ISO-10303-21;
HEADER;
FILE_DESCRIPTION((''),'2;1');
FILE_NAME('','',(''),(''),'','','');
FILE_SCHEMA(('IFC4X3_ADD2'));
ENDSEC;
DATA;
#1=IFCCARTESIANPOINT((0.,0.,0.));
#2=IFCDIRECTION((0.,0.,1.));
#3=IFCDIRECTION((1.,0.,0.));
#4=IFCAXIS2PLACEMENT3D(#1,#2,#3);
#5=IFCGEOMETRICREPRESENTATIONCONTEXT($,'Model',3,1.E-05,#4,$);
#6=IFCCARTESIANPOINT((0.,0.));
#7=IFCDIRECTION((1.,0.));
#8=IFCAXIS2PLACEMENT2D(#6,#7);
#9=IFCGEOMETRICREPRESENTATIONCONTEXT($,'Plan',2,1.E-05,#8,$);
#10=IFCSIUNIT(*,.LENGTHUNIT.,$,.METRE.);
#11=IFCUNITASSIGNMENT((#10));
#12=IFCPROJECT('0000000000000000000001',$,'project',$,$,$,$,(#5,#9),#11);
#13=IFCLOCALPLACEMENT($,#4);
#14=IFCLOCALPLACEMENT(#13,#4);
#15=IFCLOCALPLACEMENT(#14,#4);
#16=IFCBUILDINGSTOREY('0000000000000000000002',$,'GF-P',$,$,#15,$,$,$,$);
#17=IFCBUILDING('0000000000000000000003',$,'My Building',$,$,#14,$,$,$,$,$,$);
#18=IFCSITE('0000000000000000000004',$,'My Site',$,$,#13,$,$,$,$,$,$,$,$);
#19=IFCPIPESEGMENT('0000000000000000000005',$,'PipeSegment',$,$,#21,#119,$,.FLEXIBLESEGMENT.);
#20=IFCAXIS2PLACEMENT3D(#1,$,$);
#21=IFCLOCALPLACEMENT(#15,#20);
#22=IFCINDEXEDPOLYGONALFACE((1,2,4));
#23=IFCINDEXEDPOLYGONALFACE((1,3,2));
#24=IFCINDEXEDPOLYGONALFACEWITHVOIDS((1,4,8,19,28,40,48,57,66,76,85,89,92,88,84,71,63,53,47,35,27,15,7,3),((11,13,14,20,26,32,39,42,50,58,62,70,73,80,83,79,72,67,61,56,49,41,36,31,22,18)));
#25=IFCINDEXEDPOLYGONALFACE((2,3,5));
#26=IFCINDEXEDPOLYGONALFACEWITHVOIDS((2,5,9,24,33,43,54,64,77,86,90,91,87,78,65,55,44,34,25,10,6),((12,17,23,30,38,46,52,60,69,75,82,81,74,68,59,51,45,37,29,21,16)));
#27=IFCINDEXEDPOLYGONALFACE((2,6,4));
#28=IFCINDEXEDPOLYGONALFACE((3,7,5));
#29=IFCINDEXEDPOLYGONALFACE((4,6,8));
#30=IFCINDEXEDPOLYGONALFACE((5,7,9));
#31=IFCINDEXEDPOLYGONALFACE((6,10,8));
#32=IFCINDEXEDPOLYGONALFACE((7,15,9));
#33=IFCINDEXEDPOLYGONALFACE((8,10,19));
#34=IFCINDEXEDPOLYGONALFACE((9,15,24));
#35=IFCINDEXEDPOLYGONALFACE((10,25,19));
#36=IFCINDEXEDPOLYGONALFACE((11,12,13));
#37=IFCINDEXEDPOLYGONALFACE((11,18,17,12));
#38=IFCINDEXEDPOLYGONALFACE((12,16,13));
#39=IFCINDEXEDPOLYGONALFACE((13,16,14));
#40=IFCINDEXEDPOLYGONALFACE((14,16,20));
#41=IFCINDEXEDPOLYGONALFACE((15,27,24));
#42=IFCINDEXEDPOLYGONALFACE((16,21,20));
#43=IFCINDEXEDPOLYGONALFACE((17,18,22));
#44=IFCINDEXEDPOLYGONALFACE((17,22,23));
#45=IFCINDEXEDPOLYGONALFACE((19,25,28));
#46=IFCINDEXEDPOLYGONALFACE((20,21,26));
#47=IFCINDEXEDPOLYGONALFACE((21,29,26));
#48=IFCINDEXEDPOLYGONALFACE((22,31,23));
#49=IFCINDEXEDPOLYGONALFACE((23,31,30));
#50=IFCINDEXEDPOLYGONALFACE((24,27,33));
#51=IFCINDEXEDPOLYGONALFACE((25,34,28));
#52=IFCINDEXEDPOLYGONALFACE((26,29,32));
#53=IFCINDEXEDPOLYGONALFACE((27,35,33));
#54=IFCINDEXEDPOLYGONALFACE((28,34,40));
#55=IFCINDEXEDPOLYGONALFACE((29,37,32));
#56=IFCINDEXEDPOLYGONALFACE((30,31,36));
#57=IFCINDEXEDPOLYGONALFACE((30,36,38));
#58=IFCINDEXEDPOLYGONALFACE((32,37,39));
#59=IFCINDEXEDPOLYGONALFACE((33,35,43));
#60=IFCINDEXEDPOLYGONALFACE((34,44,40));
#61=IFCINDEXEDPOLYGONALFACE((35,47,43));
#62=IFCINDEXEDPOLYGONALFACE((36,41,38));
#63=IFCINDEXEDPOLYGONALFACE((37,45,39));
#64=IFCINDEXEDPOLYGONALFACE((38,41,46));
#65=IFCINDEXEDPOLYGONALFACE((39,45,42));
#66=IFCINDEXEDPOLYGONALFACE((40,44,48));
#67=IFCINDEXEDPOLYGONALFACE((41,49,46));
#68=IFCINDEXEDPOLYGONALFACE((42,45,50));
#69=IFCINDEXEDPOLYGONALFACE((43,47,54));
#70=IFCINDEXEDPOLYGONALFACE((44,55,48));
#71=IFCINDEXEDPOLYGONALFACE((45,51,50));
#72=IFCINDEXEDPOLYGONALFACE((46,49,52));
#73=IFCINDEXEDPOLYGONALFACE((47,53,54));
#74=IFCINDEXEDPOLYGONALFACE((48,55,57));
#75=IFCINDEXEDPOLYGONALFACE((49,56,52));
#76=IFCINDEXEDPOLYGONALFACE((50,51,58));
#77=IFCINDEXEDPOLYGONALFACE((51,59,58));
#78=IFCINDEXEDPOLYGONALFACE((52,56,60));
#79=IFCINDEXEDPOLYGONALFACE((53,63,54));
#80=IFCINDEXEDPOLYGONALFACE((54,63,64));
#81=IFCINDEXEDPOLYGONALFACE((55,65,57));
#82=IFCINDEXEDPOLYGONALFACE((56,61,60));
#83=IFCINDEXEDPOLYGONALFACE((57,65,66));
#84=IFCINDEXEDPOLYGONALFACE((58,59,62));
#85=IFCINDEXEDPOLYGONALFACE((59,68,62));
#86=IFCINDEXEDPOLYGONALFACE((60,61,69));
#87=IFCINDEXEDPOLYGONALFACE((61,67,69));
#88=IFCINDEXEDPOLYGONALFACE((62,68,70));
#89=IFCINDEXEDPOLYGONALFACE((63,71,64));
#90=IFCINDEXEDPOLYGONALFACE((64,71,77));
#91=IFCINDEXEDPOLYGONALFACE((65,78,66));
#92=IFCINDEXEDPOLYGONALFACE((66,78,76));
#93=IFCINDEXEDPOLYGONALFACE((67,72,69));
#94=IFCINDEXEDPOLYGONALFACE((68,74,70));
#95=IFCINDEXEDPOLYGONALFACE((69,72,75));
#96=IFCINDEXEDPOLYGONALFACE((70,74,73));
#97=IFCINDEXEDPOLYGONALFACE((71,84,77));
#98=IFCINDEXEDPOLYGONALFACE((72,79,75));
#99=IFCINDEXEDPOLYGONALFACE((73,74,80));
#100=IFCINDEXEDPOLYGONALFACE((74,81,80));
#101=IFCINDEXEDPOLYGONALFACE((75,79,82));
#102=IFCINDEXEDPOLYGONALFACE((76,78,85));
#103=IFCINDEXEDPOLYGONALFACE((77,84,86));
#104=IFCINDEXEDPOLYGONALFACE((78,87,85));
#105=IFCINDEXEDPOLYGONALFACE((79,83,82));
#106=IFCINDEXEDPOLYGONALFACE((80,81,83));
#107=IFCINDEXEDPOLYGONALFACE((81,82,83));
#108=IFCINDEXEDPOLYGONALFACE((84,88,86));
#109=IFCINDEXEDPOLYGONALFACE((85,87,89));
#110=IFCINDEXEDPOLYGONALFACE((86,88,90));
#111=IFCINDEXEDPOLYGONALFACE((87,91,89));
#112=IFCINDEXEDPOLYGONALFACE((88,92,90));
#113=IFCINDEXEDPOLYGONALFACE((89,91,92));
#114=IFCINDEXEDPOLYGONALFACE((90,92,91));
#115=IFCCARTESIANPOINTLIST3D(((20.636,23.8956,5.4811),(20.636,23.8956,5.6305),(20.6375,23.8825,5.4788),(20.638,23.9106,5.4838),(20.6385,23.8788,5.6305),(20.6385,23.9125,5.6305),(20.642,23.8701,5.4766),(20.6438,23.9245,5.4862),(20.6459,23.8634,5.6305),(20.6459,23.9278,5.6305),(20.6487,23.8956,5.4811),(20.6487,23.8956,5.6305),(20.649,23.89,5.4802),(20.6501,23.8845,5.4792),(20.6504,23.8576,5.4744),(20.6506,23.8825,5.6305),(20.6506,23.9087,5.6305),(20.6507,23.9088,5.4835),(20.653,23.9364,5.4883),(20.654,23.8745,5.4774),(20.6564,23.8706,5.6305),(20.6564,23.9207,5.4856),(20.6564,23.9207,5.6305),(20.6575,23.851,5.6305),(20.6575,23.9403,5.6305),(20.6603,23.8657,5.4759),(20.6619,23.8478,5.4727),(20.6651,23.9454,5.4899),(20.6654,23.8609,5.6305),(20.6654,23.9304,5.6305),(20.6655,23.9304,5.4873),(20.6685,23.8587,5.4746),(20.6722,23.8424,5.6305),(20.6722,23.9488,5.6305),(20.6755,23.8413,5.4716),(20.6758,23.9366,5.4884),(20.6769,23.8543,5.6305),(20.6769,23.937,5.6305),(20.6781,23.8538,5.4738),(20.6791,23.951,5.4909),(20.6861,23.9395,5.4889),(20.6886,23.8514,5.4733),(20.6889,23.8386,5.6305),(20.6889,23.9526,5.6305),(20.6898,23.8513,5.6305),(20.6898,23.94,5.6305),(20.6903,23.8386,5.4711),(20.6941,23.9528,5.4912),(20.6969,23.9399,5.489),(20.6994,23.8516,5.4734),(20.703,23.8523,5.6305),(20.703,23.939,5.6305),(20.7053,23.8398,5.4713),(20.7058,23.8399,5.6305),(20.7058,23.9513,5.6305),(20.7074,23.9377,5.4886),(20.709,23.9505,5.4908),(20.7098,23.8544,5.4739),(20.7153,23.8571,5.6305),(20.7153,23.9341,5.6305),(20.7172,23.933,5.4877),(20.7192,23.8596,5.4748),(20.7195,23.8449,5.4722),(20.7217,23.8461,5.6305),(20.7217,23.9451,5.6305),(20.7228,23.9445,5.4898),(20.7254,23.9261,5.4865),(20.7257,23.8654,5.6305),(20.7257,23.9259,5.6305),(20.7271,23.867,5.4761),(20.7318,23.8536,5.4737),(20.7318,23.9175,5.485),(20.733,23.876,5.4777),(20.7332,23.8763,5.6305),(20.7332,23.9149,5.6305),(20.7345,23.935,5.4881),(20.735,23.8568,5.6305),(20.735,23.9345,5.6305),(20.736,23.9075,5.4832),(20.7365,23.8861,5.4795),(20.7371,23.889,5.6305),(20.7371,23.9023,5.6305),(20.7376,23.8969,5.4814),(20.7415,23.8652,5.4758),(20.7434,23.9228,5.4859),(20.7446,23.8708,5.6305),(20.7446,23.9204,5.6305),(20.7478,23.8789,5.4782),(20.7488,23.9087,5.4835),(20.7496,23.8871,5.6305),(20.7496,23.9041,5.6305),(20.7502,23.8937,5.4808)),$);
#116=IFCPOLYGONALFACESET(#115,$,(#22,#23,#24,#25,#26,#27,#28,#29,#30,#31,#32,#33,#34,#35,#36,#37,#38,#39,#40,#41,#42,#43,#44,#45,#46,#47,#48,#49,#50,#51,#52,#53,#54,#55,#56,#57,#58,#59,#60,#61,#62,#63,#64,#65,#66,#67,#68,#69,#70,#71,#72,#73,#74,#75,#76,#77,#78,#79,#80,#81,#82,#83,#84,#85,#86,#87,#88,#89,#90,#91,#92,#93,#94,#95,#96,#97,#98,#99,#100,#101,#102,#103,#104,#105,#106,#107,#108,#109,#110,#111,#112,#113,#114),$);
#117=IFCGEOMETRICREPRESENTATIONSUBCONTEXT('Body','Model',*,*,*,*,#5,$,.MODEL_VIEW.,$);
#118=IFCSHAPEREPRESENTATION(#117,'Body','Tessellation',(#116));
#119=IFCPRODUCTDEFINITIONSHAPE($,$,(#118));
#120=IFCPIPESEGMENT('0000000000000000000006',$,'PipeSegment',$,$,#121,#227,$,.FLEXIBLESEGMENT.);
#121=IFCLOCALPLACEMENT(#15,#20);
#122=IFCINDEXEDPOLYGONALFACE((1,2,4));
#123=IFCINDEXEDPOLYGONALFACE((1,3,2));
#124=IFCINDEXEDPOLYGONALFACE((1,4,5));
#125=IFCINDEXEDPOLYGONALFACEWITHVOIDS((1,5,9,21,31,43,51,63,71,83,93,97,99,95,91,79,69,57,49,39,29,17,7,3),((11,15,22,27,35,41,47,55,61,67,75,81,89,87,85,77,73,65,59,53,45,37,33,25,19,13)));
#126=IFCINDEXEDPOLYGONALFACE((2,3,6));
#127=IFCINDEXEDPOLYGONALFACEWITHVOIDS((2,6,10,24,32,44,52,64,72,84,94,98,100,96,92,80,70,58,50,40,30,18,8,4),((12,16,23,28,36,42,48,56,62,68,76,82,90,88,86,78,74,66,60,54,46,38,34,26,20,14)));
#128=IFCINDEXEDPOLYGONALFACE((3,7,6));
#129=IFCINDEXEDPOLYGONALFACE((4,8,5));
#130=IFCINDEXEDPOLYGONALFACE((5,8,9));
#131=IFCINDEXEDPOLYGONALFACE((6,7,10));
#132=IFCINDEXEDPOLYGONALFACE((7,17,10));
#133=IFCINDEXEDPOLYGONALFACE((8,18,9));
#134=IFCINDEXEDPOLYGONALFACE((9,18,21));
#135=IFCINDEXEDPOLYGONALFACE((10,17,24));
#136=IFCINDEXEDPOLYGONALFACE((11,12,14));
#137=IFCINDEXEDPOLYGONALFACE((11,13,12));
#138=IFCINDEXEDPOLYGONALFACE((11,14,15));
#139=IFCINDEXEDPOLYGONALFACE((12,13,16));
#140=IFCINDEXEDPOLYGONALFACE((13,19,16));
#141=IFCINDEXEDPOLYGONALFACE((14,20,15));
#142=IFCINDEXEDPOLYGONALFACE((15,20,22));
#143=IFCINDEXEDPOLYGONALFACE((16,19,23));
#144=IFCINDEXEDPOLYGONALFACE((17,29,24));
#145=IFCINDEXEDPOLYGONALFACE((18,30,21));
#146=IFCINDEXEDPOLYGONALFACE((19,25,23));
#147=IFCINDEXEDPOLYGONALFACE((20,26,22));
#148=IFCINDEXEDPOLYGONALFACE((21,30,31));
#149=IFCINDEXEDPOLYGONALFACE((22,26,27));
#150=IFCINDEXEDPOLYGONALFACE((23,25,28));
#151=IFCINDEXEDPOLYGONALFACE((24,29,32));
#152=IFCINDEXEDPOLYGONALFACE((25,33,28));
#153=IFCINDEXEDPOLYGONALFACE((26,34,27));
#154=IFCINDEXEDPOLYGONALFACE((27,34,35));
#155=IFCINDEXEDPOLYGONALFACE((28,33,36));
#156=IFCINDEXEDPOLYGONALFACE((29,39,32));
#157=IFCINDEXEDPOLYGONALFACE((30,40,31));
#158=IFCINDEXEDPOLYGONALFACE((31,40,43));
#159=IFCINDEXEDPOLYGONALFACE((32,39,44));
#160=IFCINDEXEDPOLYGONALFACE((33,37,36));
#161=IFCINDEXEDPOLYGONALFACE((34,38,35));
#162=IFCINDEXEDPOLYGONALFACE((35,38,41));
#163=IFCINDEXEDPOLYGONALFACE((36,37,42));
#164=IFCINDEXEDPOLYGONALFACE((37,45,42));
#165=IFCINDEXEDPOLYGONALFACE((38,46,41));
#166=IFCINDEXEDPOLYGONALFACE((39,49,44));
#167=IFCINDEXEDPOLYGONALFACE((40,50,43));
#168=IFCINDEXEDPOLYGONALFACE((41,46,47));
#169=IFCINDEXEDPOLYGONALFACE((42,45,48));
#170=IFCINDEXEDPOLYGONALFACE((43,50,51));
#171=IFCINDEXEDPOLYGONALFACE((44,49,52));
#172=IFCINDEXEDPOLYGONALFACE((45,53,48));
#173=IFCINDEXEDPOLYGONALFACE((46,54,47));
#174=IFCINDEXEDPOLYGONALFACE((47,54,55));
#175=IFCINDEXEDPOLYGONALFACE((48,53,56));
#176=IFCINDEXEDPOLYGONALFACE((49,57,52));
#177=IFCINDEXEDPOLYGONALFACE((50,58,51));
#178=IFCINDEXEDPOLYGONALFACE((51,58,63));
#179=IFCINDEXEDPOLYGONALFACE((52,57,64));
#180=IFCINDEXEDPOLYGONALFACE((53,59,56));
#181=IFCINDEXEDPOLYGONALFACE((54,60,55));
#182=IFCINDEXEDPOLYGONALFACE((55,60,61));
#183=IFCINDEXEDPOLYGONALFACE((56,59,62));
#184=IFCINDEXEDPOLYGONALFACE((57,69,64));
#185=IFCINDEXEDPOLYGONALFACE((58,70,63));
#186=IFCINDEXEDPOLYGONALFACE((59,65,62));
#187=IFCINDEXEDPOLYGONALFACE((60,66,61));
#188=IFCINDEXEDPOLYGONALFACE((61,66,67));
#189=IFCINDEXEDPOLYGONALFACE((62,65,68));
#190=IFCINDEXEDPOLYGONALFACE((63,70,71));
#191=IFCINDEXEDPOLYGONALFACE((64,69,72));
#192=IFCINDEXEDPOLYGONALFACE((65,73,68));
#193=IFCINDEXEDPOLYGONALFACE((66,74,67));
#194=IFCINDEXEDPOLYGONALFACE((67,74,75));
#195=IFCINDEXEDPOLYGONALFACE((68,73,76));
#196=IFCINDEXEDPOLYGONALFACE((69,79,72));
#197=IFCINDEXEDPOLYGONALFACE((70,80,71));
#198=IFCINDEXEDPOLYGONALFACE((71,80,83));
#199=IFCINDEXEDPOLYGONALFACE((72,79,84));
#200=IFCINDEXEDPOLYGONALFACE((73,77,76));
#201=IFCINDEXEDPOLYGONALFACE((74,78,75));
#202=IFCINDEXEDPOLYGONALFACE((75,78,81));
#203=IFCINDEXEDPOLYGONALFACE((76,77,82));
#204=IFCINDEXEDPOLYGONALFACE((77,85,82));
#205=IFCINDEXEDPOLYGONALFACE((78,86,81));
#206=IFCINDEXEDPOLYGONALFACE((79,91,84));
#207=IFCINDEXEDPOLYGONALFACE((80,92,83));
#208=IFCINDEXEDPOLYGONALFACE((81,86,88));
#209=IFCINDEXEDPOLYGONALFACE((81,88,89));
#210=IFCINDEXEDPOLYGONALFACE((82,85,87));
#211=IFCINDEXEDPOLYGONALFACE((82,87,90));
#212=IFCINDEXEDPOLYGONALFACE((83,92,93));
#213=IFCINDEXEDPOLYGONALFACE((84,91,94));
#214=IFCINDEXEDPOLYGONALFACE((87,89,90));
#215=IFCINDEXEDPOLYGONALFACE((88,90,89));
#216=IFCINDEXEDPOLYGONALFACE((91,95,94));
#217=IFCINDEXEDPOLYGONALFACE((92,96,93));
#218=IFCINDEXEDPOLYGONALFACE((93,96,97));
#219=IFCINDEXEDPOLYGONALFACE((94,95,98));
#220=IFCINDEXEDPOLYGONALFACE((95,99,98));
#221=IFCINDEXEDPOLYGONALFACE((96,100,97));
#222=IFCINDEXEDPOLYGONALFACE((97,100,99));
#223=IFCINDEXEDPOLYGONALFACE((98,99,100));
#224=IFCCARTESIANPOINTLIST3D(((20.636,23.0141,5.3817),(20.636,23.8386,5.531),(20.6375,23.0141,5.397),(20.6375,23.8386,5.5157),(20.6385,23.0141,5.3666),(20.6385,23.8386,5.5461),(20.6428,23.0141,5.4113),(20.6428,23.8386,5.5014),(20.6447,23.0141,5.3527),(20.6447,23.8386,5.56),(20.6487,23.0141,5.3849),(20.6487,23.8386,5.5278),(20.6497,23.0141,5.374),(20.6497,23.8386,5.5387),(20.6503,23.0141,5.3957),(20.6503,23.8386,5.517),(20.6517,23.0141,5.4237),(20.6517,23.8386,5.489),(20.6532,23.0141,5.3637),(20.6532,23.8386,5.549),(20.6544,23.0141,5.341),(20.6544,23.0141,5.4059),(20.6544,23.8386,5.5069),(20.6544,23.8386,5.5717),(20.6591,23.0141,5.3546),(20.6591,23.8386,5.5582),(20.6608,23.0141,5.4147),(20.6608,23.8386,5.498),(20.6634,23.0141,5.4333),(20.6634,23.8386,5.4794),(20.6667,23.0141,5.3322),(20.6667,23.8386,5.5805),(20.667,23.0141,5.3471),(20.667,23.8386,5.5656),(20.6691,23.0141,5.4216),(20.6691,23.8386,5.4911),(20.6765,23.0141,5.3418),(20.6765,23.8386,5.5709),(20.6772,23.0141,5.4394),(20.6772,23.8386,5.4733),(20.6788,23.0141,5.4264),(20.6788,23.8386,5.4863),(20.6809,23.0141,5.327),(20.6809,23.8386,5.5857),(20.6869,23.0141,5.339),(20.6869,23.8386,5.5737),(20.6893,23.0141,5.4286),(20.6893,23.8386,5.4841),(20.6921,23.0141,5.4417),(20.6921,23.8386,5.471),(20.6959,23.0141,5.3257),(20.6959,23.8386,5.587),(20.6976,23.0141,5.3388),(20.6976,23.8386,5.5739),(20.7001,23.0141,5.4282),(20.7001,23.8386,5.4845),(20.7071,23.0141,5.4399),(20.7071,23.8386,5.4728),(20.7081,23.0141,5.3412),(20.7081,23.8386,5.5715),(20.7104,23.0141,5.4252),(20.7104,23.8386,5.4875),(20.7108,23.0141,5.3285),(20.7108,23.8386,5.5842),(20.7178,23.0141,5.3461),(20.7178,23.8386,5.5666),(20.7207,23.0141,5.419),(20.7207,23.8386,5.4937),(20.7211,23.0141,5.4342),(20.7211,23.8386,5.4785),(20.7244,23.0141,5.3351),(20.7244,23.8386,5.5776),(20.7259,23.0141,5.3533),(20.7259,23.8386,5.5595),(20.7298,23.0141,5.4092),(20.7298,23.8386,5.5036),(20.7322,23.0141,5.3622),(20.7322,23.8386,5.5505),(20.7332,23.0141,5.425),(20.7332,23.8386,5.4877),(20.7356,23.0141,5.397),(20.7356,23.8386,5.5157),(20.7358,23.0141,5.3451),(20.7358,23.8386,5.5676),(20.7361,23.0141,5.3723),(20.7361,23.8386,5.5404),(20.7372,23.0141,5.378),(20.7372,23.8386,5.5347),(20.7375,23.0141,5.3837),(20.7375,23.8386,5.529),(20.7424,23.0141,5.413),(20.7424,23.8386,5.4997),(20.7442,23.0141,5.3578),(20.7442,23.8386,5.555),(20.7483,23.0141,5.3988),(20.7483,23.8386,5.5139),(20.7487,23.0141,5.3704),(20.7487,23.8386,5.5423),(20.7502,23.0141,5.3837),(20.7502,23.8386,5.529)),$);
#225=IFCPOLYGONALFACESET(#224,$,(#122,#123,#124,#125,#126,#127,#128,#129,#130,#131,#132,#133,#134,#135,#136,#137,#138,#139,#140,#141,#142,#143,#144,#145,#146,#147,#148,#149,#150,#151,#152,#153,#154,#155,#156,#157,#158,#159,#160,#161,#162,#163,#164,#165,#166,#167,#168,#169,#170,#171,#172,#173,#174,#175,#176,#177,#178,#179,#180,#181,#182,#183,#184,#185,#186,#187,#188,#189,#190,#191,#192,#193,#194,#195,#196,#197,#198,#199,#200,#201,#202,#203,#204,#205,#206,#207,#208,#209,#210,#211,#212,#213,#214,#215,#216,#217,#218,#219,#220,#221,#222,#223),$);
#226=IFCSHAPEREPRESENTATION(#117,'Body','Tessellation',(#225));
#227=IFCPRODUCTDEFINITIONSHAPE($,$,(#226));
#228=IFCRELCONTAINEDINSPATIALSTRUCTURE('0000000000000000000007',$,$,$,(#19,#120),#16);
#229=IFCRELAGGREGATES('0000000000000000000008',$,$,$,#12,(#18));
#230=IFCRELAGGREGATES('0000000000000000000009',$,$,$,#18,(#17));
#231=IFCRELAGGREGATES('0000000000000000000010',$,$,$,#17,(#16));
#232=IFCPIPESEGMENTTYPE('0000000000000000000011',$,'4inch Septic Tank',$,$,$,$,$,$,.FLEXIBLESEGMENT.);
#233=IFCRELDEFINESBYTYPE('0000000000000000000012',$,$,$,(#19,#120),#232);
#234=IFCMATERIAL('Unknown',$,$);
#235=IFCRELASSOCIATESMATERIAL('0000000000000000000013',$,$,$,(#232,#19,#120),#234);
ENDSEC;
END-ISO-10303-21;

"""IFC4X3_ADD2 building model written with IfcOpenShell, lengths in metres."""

from ifc_helpers import new_model, si_unit, frame, origin_with_axes, origin_2d_with_axis, place, context, subcontext, project, spatial, hollow_circle, extrude, clip, halfspace, material, material_profile, profile_set, profile_usage, type_object, element, save


model = new_model("IFC4X3_ADD2")

# Units and contexts
model_context = context("Model", 3, precision=1e-05, world=origin_with_axes())
plan_context = context("Plan", 2, precision=1e-05, world=origin_2d_with_axis())
body_context = subcontext(model_context, "Body", "Model", "MODEL_VIEW")
ifc_project = project(units=[si_unit("LENGTHUNIT", "METRE")], contexts=[model_context, plan_context])

# Site, building, storey
site_placement = place(None, origin_with_axes())
site = spatial("IfcSite", under=ifc_project, at=site_placement, Name="My Site")
building_placement = place(site_placement, origin_with_axes())
building = spatial("IfcBuilding", under=site, at=building_placement, Name="My Building")
storey_placement = place(building_placement, origin_with_axes())
storey = spatial("IfcBuildingStorey", under=building, at=storey_placement, Name="GF-P")

# Pipe segments
ifc_material_1 = material(Name="Unknown")
ifc_material_profile_1 = material_profile(ifc_material_1, hollow_circle(Radius=0.0571, WallThickness=0.0127))
ifc_profile_set_1 = profile_set([ifc_material_profile_1], Name="blackwater")
pipe_segment_type_1 = type_object("IfcPipeSegmentType", Name="4inch Septic Tank", PredefinedType="FLEXIBLESEGMENT", material=ifc_profile_set_1)
ifc_profile_usage_1 = profile_usage(ifc_profile_set_1, cardinal=5)
pipe_segment_1_placement = place(storey_placement, frame((20.6931, 23.8956, 5.3795), z_axis=(0.0, 0.0, 1.0), x_axis=(-1.0, 0.0, 0.0)))
element("IfcPipeSegment", 1, at=pipe_segment_1_placement, inside=storey, type_object=pipe_segment_type_1, material=ifc_profile_usage_1, Name="PipeSegment", PredefinedType="FLEXIBLESEGMENT", context=body_context, shape_type="Clipping", body=[
    clip(extrude(hollow_circle(Radius=0.0571, WallThickness=0.0127), origin_with_axes(), (0.0, 0.0, 1.0), 0.2509), halfspace(frame((0.0, 0.9655, -0.0686), z_axis=(0.0, -0.173648, -0.984808), x_axis=(-1.0, 0.0, 0.0)), False)),
])
ifc_profile_usage_2 = profile_usage(ifc_profile_set_1, cardinal=5)
pipe_segment_2_placement = place(storey_placement, frame((20.6931, 22.9016, 5.3638), z_axis=(0.0, 0.984808, 0.173648), x_axis=(1.0, 0.0, 0.0)))
element("IfcPipeSegment", 2, at=pipe_segment_2_placement, inside=storey, type_object=pipe_segment_type_1, material=ifc_profile_usage_2, Name="PipeSegment", PredefinedType="FLEXIBLESEGMENT", context=body_context, shape_type="Clipping", body=[
    clip(clip(extrude(hollow_circle(Radius=0.0571, WallThickness=0.0127), origin_with_axes(), (0.0, 0.0, 1.0), 1.0656), halfspace(frame((0.0, 0.1472, 0.9254), z_axis=(0.0, 0.173648, 0.984808), x_axis=(1.0, 0.000002, 0.0)), False)), halfspace(frame((0.4801, 5.4997, -0.8555), z_axis=(0.0, -0.173648, -0.984808), x_axis=(-1.0, -0.000002, 0.0)), False)),
])

save(model, "model.ifc")
